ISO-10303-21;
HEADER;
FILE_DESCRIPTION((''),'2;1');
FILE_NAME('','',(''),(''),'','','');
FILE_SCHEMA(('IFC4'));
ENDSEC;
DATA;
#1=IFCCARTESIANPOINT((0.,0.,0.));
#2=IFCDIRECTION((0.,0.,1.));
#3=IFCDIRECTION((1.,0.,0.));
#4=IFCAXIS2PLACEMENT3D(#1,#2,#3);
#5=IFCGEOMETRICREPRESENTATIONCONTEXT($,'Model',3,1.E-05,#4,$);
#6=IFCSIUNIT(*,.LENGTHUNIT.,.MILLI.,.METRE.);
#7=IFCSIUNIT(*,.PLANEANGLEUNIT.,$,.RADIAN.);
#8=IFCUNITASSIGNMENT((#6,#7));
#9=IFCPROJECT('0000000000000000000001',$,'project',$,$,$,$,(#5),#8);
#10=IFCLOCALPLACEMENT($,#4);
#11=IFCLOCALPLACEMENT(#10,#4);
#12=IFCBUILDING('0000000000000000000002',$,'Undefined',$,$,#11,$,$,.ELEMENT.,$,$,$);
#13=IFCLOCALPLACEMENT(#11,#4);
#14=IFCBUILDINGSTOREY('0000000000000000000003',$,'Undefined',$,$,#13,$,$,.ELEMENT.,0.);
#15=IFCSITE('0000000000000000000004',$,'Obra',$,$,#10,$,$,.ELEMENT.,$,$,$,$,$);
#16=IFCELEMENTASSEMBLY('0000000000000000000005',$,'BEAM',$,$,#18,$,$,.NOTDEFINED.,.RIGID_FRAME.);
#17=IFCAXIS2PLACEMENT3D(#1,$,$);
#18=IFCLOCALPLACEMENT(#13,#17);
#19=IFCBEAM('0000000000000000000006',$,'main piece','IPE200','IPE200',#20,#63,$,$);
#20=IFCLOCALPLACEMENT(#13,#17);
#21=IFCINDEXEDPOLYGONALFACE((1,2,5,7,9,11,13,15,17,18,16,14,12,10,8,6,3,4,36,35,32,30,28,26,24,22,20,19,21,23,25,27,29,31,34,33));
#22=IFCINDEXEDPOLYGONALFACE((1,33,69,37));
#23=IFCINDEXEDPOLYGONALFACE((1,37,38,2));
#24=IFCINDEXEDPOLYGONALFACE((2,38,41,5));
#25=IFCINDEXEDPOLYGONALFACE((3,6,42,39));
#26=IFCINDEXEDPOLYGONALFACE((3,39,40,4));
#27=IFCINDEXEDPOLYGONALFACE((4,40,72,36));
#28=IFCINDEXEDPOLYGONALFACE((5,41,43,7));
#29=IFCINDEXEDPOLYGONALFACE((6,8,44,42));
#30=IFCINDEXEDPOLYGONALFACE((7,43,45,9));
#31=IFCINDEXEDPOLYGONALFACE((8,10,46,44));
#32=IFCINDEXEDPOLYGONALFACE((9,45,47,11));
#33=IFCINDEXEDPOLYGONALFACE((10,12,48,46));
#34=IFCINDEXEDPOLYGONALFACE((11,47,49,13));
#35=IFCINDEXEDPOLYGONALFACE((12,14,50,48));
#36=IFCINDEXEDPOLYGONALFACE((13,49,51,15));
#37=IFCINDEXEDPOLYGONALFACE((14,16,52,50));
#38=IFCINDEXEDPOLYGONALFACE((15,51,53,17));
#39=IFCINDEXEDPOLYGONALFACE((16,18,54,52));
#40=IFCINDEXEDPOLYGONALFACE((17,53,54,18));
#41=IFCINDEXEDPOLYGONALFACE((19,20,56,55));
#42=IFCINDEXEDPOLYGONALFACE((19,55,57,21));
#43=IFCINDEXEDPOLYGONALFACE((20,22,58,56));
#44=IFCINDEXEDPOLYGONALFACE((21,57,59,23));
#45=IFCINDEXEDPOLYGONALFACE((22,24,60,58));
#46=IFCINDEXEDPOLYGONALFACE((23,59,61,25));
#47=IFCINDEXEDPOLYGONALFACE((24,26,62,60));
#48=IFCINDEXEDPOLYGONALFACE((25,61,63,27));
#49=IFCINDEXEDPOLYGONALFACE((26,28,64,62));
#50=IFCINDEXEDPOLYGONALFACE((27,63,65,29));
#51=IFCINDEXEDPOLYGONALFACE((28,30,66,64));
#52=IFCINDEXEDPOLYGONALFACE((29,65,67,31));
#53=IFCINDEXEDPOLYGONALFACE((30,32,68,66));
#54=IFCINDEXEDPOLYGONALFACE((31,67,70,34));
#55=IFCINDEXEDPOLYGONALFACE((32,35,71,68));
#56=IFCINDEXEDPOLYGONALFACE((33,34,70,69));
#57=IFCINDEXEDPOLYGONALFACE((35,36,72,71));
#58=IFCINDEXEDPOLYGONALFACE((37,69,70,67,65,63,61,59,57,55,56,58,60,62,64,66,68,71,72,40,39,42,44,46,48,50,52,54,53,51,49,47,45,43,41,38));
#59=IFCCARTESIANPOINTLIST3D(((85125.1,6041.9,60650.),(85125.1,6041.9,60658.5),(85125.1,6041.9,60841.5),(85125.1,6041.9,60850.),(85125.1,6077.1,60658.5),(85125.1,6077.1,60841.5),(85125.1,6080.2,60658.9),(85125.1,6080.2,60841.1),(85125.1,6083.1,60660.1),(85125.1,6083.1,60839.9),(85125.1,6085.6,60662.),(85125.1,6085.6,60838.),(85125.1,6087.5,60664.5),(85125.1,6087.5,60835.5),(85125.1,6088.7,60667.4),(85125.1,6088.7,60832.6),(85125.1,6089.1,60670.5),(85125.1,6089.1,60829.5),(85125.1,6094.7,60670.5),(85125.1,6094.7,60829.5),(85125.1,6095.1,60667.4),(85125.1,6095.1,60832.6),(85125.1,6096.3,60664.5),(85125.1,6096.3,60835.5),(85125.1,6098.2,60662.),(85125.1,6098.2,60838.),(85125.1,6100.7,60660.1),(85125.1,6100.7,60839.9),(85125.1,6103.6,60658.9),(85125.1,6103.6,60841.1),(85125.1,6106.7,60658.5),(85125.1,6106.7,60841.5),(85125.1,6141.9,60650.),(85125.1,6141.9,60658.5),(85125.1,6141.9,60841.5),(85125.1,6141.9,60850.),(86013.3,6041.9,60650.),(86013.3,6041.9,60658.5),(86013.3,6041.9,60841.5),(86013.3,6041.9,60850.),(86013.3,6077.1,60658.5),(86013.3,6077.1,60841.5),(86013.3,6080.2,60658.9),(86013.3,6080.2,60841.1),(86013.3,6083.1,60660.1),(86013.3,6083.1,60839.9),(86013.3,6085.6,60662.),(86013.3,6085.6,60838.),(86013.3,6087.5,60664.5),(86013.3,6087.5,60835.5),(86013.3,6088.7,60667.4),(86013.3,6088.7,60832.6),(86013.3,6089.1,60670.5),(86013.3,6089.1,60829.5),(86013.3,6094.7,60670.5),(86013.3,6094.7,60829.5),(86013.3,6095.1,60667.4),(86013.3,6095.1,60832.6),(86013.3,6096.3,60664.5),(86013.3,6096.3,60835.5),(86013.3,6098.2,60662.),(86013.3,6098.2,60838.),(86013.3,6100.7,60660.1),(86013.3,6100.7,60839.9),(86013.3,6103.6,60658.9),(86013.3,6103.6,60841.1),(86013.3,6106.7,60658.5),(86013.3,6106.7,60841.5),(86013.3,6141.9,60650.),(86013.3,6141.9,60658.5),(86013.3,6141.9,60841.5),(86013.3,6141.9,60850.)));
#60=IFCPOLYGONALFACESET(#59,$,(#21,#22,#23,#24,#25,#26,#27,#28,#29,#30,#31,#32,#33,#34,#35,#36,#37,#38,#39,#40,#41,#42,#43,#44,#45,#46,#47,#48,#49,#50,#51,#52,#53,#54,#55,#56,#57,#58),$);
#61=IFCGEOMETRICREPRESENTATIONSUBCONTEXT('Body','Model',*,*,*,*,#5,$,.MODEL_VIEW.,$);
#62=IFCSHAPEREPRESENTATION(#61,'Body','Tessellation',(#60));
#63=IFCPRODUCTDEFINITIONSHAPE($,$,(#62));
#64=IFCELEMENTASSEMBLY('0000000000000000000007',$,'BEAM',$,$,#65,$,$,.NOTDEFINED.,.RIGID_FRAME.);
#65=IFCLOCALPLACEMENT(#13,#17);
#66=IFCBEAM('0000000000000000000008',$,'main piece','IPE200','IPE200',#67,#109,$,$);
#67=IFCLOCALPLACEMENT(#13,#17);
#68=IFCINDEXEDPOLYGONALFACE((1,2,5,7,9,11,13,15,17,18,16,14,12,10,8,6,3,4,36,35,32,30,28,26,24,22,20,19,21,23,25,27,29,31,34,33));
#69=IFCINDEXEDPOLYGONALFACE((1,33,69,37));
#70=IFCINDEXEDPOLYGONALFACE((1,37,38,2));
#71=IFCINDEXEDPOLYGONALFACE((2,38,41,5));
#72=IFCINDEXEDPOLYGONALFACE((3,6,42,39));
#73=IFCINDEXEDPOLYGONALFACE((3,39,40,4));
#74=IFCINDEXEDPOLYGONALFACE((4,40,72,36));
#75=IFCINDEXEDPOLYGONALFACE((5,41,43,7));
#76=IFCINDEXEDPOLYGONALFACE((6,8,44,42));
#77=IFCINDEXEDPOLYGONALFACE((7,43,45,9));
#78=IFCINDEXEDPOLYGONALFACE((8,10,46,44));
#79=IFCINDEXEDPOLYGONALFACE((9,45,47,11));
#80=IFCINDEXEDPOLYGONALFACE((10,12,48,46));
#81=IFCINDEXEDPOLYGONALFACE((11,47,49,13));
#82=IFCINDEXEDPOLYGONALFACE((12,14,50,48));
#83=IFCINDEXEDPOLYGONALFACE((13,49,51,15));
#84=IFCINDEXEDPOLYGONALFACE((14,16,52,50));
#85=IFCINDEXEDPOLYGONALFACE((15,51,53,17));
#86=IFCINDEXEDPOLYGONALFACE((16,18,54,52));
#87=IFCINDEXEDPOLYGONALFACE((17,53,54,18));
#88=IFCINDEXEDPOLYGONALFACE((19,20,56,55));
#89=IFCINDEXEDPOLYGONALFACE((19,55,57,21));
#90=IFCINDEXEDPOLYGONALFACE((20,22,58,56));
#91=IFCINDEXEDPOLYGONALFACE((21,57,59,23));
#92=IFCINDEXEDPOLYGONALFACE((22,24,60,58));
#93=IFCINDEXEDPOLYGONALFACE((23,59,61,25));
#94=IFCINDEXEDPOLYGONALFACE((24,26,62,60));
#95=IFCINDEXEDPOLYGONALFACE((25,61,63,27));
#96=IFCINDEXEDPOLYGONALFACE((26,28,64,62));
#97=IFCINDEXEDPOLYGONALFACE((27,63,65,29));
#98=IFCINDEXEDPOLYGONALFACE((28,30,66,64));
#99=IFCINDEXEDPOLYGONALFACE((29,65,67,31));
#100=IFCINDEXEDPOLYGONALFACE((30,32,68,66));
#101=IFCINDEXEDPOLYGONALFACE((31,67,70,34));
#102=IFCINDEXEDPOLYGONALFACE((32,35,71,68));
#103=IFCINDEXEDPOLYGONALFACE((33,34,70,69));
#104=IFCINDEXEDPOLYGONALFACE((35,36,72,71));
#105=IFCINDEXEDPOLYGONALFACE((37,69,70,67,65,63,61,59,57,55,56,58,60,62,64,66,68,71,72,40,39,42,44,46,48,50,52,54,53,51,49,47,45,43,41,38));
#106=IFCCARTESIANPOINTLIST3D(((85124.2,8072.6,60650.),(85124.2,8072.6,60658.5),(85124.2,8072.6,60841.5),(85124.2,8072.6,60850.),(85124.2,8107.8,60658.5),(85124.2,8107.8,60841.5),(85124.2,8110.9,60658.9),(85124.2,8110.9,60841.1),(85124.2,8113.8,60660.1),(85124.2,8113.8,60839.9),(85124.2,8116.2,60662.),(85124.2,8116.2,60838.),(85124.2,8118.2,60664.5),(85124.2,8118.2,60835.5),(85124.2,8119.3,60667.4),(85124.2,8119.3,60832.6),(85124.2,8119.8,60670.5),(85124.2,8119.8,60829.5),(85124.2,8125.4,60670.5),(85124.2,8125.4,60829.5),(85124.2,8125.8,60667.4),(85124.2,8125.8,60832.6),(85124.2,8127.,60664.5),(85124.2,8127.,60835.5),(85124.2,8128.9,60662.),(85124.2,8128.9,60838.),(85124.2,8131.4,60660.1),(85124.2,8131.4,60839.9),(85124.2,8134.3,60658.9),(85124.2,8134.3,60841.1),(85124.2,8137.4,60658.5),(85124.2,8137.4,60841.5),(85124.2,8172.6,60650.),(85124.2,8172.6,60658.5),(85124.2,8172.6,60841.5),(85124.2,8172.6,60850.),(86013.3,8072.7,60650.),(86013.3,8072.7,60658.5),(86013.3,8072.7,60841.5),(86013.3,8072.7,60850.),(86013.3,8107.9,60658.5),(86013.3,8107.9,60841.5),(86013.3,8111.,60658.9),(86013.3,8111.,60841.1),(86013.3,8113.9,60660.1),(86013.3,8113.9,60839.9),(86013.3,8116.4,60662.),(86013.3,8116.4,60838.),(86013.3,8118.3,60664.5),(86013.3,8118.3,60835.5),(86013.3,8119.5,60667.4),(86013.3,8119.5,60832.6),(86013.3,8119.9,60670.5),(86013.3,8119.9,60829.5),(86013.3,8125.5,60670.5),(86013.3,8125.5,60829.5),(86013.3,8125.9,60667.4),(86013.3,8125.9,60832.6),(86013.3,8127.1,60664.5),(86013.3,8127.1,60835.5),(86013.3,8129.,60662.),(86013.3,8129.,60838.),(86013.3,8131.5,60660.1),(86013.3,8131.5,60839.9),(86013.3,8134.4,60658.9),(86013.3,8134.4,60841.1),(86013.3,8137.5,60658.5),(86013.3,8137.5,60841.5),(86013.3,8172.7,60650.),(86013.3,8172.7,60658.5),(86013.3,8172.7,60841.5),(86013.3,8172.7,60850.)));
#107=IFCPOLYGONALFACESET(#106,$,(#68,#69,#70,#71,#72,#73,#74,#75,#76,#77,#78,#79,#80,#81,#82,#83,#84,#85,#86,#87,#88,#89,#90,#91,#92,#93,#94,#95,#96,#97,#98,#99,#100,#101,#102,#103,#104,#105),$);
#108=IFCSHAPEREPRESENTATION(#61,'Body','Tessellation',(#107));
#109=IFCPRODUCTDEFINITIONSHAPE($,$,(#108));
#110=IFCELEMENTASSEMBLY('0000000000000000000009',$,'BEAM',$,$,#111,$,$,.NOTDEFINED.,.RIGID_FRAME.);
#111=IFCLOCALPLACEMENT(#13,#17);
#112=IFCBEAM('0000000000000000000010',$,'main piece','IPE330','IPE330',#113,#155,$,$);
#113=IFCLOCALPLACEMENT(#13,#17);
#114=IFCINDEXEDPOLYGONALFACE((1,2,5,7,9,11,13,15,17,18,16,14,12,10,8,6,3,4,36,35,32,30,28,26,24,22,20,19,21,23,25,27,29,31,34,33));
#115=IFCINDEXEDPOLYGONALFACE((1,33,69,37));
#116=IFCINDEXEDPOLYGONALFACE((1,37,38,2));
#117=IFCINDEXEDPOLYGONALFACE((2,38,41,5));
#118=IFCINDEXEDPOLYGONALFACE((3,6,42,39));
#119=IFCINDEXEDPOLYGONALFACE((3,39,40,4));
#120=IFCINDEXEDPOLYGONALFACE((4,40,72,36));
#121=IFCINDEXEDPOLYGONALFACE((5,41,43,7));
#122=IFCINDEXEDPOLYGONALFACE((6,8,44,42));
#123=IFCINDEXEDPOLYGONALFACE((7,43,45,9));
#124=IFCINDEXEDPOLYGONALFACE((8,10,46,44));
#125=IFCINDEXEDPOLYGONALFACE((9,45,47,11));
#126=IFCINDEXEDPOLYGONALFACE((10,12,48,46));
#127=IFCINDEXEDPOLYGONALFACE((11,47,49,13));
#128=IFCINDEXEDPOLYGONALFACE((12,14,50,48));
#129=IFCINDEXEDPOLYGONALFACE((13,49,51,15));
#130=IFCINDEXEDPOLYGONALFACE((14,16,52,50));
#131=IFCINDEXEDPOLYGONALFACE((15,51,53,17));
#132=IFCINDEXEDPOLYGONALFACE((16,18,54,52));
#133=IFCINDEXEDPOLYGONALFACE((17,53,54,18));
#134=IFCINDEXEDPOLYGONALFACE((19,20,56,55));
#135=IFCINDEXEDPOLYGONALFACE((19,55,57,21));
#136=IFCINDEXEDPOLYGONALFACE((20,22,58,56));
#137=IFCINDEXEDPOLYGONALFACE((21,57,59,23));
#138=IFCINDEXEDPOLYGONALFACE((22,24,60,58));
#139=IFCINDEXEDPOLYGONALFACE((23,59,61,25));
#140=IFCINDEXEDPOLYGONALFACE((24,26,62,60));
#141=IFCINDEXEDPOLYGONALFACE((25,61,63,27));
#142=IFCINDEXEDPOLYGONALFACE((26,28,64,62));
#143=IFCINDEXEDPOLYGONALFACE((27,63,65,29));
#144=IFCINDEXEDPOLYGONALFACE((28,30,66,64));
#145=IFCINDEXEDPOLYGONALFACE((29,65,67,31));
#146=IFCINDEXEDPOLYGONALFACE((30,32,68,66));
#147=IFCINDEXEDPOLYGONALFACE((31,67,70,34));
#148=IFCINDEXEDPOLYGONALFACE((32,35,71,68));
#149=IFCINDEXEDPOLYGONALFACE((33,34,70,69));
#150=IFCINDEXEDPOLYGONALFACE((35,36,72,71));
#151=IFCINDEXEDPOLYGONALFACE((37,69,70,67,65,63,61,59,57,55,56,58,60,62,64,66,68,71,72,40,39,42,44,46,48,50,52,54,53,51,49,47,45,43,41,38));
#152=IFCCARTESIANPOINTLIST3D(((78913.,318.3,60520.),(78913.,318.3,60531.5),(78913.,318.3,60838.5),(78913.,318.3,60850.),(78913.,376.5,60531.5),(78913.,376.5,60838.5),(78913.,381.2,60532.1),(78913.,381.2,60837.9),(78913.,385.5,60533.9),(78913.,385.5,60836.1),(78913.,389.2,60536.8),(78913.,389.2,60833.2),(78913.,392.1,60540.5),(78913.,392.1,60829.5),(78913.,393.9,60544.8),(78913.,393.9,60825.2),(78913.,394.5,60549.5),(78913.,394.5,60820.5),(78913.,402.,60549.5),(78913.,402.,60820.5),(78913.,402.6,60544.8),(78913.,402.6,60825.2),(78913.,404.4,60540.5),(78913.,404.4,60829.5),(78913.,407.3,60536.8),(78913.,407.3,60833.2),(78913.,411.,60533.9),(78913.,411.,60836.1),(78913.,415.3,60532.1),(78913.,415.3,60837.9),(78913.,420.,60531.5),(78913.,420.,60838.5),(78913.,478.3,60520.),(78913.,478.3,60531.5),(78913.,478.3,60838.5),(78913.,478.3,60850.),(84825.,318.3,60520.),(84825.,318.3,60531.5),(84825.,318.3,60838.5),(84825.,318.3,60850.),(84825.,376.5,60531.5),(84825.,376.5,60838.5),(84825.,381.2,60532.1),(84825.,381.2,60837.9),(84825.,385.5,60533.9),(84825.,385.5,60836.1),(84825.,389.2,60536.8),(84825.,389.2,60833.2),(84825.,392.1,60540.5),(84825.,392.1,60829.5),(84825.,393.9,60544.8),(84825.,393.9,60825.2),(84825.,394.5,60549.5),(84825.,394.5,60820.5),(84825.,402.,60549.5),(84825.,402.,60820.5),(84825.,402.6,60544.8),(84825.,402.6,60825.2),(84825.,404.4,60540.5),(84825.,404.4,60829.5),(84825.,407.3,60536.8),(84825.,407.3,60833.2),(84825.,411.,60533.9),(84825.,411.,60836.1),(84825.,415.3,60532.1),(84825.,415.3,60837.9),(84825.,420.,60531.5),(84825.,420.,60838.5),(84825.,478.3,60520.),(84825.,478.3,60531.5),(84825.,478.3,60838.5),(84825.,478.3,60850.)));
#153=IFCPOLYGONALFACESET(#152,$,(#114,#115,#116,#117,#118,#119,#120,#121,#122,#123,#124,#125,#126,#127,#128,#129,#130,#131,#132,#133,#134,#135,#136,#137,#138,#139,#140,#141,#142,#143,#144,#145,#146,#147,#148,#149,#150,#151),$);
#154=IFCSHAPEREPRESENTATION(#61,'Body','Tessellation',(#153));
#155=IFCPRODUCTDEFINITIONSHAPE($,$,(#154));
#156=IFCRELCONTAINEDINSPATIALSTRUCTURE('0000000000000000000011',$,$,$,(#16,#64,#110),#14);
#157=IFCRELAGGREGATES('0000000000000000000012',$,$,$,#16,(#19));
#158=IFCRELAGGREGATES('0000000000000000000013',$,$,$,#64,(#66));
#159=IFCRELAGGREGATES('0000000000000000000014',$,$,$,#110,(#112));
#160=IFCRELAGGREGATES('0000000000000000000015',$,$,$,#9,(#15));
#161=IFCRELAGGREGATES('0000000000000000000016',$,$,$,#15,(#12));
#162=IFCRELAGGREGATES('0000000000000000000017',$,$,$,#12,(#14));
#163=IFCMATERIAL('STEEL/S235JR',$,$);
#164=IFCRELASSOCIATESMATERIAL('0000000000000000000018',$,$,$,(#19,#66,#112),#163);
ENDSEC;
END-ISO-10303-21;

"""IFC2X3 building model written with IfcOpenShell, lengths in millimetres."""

from ifc_helpers import new_model, si_unit, frame, origin_with_axes, origin_2d_with_axis, place, context, subcontext, project, spatial, i_section, extrude, material, element, aggregate, save


model = new_model("IFC2X3")

# Units and contexts
model_context = context("Model", 3, precision=1e-05, world=origin_with_axes())
body_context = subcontext(model_context, "Body", "Model", "MODEL_VIEW")
ifc_project = project(units=[si_unit("LENGTHUNIT", "METRE", prefix="MILLI"), si_unit("PLANEANGLEUNIT", "RADIAN")], contexts=[model_context])

# Site, building, storey
site_placement = place(None, origin_with_axes())
site = spatial("IfcSite", under=ifc_project, at=site_placement, Name="Obra", CompositionType="ELEMENT")
building_placement = place(site_placement, origin_with_axes())
building = spatial("IfcBuilding", under=site, at=building_placement, Name="Undefined", CompositionType="ELEMENT")
storey_placement = place(building_placement, origin_with_axes())
storey = spatial("IfcBuildingStorey", under=building, at=storey_placement, Name="Undefined", CompositionType="ELEMENT", Elevation=0.0)

# Shared definitions
ifc_material_1 = material(Name="STEEL/S235JR")

# Element assemblies, beams
assembly_1_placement = place(storey_placement, origin_with_axes())
assembly_1 = element("IfcElementAssembly", 1, at=assembly_1_placement, inside=storey, Name="BEAM", AssemblyPlace="NOTDEFINED", PredefinedType="RIGID_FRAME")
beam_1_placement = place(assembly_1_placement, frame((85125.0, 6091.9, 60750.0), z_axis=(0.0, 0.0, 1.0), x_axis=(1.0, 0.0, 0.0)))
beam_1 = element("IfcBeam", 2, at=beam_1_placement, material=ifc_material_1, Name="main piece", Description="IPE200", ObjectType="IPE200", context=body_context, shape_type="SweptSolid", body=[
    extrude(i_section(OverallWidth=100.0, OverallDepth=200.0, WebThickness=5.6, FlangeThickness=8.5, FilletRadius=12.0, at=origin_2d_with_axis()), frame((888.3, 0.0, 0.0), z_axis=(-1.0, 0.0, 0.0), x_axis=(0.0, -1.0, 0.0)), (0.0, 0.0, 1.0), 888.2),
])
aggregate(assembly_1, [beam_1])
assembly_2_placement = place(storey_placement, origin_with_axes())
assembly_2 = element("IfcElementAssembly", 3, at=assembly_2_placement, inside=storey, Name="BEAM", AssemblyPlace="NOTDEFINED", PredefinedType="RIGID_FRAME")
beam_2_placement = place(assembly_2_placement, frame((85124.2, 8122.6, 60750.0), z_axis=(0.0, 0.0, 1.0), x_axis=(1.0, 0.000161, 0.0)))
beam_2 = element("IfcBeam", 4, at=beam_2_placement, material=ifc_material_1, Name="main piece", Description="IPE200", ObjectType="IPE200", context=body_context, shape_type="SweptSolid", body=[
    extrude(i_section(OverallWidth=100.0, OverallDepth=200.0, WebThickness=5.6, FlangeThickness=8.5, FilletRadius=12.0, at=origin_2d_with_axis()), frame((889.1, 0.0, 0.0), z_axis=(-1.0, 0.0, 0.0), x_axis=(0.0, -1.0, 0.0)), (0.0, 0.0, 1.0), 889.1),
])
aggregate(assembly_2, [beam_2])
assembly_3_placement = place(storey_placement, origin_with_axes())
assembly_3 = element("IfcElementAssembly", 5, at=assembly_3_placement, inside=storey, Name="BEAM", AssemblyPlace="NOTDEFINED", PredefinedType="RIGID_FRAME")
beam_3_placement = place(assembly_3_placement, frame((78913.0, 398.3, 60685.0), z_axis=(0.0, 0.0, 1.0), x_axis=(1.0, 0.0, 0.0)))
beam_3 = element("IfcBeam", 6, at=beam_3_placement, material=ifc_material_1, Name="main piece", Description="IPE330", ObjectType="IPE330", context=body_context, shape_type="SweptSolid", body=[
    extrude(i_section(OverallWidth=160.0, OverallDepth=330.0, WebThickness=7.5, FlangeThickness=11.5, FilletRadius=18.0, at=origin_2d_with_axis()), frame((5912.0, 0.0, 0.0), z_axis=(-1.0, 0.0, 0.0), x_axis=(0.0, -1.0, 0.0)), (0.0, 0.0, 1.0), 5912.0),
])
aggregate(assembly_3, [beam_3])

save(model, "model.ifc")
